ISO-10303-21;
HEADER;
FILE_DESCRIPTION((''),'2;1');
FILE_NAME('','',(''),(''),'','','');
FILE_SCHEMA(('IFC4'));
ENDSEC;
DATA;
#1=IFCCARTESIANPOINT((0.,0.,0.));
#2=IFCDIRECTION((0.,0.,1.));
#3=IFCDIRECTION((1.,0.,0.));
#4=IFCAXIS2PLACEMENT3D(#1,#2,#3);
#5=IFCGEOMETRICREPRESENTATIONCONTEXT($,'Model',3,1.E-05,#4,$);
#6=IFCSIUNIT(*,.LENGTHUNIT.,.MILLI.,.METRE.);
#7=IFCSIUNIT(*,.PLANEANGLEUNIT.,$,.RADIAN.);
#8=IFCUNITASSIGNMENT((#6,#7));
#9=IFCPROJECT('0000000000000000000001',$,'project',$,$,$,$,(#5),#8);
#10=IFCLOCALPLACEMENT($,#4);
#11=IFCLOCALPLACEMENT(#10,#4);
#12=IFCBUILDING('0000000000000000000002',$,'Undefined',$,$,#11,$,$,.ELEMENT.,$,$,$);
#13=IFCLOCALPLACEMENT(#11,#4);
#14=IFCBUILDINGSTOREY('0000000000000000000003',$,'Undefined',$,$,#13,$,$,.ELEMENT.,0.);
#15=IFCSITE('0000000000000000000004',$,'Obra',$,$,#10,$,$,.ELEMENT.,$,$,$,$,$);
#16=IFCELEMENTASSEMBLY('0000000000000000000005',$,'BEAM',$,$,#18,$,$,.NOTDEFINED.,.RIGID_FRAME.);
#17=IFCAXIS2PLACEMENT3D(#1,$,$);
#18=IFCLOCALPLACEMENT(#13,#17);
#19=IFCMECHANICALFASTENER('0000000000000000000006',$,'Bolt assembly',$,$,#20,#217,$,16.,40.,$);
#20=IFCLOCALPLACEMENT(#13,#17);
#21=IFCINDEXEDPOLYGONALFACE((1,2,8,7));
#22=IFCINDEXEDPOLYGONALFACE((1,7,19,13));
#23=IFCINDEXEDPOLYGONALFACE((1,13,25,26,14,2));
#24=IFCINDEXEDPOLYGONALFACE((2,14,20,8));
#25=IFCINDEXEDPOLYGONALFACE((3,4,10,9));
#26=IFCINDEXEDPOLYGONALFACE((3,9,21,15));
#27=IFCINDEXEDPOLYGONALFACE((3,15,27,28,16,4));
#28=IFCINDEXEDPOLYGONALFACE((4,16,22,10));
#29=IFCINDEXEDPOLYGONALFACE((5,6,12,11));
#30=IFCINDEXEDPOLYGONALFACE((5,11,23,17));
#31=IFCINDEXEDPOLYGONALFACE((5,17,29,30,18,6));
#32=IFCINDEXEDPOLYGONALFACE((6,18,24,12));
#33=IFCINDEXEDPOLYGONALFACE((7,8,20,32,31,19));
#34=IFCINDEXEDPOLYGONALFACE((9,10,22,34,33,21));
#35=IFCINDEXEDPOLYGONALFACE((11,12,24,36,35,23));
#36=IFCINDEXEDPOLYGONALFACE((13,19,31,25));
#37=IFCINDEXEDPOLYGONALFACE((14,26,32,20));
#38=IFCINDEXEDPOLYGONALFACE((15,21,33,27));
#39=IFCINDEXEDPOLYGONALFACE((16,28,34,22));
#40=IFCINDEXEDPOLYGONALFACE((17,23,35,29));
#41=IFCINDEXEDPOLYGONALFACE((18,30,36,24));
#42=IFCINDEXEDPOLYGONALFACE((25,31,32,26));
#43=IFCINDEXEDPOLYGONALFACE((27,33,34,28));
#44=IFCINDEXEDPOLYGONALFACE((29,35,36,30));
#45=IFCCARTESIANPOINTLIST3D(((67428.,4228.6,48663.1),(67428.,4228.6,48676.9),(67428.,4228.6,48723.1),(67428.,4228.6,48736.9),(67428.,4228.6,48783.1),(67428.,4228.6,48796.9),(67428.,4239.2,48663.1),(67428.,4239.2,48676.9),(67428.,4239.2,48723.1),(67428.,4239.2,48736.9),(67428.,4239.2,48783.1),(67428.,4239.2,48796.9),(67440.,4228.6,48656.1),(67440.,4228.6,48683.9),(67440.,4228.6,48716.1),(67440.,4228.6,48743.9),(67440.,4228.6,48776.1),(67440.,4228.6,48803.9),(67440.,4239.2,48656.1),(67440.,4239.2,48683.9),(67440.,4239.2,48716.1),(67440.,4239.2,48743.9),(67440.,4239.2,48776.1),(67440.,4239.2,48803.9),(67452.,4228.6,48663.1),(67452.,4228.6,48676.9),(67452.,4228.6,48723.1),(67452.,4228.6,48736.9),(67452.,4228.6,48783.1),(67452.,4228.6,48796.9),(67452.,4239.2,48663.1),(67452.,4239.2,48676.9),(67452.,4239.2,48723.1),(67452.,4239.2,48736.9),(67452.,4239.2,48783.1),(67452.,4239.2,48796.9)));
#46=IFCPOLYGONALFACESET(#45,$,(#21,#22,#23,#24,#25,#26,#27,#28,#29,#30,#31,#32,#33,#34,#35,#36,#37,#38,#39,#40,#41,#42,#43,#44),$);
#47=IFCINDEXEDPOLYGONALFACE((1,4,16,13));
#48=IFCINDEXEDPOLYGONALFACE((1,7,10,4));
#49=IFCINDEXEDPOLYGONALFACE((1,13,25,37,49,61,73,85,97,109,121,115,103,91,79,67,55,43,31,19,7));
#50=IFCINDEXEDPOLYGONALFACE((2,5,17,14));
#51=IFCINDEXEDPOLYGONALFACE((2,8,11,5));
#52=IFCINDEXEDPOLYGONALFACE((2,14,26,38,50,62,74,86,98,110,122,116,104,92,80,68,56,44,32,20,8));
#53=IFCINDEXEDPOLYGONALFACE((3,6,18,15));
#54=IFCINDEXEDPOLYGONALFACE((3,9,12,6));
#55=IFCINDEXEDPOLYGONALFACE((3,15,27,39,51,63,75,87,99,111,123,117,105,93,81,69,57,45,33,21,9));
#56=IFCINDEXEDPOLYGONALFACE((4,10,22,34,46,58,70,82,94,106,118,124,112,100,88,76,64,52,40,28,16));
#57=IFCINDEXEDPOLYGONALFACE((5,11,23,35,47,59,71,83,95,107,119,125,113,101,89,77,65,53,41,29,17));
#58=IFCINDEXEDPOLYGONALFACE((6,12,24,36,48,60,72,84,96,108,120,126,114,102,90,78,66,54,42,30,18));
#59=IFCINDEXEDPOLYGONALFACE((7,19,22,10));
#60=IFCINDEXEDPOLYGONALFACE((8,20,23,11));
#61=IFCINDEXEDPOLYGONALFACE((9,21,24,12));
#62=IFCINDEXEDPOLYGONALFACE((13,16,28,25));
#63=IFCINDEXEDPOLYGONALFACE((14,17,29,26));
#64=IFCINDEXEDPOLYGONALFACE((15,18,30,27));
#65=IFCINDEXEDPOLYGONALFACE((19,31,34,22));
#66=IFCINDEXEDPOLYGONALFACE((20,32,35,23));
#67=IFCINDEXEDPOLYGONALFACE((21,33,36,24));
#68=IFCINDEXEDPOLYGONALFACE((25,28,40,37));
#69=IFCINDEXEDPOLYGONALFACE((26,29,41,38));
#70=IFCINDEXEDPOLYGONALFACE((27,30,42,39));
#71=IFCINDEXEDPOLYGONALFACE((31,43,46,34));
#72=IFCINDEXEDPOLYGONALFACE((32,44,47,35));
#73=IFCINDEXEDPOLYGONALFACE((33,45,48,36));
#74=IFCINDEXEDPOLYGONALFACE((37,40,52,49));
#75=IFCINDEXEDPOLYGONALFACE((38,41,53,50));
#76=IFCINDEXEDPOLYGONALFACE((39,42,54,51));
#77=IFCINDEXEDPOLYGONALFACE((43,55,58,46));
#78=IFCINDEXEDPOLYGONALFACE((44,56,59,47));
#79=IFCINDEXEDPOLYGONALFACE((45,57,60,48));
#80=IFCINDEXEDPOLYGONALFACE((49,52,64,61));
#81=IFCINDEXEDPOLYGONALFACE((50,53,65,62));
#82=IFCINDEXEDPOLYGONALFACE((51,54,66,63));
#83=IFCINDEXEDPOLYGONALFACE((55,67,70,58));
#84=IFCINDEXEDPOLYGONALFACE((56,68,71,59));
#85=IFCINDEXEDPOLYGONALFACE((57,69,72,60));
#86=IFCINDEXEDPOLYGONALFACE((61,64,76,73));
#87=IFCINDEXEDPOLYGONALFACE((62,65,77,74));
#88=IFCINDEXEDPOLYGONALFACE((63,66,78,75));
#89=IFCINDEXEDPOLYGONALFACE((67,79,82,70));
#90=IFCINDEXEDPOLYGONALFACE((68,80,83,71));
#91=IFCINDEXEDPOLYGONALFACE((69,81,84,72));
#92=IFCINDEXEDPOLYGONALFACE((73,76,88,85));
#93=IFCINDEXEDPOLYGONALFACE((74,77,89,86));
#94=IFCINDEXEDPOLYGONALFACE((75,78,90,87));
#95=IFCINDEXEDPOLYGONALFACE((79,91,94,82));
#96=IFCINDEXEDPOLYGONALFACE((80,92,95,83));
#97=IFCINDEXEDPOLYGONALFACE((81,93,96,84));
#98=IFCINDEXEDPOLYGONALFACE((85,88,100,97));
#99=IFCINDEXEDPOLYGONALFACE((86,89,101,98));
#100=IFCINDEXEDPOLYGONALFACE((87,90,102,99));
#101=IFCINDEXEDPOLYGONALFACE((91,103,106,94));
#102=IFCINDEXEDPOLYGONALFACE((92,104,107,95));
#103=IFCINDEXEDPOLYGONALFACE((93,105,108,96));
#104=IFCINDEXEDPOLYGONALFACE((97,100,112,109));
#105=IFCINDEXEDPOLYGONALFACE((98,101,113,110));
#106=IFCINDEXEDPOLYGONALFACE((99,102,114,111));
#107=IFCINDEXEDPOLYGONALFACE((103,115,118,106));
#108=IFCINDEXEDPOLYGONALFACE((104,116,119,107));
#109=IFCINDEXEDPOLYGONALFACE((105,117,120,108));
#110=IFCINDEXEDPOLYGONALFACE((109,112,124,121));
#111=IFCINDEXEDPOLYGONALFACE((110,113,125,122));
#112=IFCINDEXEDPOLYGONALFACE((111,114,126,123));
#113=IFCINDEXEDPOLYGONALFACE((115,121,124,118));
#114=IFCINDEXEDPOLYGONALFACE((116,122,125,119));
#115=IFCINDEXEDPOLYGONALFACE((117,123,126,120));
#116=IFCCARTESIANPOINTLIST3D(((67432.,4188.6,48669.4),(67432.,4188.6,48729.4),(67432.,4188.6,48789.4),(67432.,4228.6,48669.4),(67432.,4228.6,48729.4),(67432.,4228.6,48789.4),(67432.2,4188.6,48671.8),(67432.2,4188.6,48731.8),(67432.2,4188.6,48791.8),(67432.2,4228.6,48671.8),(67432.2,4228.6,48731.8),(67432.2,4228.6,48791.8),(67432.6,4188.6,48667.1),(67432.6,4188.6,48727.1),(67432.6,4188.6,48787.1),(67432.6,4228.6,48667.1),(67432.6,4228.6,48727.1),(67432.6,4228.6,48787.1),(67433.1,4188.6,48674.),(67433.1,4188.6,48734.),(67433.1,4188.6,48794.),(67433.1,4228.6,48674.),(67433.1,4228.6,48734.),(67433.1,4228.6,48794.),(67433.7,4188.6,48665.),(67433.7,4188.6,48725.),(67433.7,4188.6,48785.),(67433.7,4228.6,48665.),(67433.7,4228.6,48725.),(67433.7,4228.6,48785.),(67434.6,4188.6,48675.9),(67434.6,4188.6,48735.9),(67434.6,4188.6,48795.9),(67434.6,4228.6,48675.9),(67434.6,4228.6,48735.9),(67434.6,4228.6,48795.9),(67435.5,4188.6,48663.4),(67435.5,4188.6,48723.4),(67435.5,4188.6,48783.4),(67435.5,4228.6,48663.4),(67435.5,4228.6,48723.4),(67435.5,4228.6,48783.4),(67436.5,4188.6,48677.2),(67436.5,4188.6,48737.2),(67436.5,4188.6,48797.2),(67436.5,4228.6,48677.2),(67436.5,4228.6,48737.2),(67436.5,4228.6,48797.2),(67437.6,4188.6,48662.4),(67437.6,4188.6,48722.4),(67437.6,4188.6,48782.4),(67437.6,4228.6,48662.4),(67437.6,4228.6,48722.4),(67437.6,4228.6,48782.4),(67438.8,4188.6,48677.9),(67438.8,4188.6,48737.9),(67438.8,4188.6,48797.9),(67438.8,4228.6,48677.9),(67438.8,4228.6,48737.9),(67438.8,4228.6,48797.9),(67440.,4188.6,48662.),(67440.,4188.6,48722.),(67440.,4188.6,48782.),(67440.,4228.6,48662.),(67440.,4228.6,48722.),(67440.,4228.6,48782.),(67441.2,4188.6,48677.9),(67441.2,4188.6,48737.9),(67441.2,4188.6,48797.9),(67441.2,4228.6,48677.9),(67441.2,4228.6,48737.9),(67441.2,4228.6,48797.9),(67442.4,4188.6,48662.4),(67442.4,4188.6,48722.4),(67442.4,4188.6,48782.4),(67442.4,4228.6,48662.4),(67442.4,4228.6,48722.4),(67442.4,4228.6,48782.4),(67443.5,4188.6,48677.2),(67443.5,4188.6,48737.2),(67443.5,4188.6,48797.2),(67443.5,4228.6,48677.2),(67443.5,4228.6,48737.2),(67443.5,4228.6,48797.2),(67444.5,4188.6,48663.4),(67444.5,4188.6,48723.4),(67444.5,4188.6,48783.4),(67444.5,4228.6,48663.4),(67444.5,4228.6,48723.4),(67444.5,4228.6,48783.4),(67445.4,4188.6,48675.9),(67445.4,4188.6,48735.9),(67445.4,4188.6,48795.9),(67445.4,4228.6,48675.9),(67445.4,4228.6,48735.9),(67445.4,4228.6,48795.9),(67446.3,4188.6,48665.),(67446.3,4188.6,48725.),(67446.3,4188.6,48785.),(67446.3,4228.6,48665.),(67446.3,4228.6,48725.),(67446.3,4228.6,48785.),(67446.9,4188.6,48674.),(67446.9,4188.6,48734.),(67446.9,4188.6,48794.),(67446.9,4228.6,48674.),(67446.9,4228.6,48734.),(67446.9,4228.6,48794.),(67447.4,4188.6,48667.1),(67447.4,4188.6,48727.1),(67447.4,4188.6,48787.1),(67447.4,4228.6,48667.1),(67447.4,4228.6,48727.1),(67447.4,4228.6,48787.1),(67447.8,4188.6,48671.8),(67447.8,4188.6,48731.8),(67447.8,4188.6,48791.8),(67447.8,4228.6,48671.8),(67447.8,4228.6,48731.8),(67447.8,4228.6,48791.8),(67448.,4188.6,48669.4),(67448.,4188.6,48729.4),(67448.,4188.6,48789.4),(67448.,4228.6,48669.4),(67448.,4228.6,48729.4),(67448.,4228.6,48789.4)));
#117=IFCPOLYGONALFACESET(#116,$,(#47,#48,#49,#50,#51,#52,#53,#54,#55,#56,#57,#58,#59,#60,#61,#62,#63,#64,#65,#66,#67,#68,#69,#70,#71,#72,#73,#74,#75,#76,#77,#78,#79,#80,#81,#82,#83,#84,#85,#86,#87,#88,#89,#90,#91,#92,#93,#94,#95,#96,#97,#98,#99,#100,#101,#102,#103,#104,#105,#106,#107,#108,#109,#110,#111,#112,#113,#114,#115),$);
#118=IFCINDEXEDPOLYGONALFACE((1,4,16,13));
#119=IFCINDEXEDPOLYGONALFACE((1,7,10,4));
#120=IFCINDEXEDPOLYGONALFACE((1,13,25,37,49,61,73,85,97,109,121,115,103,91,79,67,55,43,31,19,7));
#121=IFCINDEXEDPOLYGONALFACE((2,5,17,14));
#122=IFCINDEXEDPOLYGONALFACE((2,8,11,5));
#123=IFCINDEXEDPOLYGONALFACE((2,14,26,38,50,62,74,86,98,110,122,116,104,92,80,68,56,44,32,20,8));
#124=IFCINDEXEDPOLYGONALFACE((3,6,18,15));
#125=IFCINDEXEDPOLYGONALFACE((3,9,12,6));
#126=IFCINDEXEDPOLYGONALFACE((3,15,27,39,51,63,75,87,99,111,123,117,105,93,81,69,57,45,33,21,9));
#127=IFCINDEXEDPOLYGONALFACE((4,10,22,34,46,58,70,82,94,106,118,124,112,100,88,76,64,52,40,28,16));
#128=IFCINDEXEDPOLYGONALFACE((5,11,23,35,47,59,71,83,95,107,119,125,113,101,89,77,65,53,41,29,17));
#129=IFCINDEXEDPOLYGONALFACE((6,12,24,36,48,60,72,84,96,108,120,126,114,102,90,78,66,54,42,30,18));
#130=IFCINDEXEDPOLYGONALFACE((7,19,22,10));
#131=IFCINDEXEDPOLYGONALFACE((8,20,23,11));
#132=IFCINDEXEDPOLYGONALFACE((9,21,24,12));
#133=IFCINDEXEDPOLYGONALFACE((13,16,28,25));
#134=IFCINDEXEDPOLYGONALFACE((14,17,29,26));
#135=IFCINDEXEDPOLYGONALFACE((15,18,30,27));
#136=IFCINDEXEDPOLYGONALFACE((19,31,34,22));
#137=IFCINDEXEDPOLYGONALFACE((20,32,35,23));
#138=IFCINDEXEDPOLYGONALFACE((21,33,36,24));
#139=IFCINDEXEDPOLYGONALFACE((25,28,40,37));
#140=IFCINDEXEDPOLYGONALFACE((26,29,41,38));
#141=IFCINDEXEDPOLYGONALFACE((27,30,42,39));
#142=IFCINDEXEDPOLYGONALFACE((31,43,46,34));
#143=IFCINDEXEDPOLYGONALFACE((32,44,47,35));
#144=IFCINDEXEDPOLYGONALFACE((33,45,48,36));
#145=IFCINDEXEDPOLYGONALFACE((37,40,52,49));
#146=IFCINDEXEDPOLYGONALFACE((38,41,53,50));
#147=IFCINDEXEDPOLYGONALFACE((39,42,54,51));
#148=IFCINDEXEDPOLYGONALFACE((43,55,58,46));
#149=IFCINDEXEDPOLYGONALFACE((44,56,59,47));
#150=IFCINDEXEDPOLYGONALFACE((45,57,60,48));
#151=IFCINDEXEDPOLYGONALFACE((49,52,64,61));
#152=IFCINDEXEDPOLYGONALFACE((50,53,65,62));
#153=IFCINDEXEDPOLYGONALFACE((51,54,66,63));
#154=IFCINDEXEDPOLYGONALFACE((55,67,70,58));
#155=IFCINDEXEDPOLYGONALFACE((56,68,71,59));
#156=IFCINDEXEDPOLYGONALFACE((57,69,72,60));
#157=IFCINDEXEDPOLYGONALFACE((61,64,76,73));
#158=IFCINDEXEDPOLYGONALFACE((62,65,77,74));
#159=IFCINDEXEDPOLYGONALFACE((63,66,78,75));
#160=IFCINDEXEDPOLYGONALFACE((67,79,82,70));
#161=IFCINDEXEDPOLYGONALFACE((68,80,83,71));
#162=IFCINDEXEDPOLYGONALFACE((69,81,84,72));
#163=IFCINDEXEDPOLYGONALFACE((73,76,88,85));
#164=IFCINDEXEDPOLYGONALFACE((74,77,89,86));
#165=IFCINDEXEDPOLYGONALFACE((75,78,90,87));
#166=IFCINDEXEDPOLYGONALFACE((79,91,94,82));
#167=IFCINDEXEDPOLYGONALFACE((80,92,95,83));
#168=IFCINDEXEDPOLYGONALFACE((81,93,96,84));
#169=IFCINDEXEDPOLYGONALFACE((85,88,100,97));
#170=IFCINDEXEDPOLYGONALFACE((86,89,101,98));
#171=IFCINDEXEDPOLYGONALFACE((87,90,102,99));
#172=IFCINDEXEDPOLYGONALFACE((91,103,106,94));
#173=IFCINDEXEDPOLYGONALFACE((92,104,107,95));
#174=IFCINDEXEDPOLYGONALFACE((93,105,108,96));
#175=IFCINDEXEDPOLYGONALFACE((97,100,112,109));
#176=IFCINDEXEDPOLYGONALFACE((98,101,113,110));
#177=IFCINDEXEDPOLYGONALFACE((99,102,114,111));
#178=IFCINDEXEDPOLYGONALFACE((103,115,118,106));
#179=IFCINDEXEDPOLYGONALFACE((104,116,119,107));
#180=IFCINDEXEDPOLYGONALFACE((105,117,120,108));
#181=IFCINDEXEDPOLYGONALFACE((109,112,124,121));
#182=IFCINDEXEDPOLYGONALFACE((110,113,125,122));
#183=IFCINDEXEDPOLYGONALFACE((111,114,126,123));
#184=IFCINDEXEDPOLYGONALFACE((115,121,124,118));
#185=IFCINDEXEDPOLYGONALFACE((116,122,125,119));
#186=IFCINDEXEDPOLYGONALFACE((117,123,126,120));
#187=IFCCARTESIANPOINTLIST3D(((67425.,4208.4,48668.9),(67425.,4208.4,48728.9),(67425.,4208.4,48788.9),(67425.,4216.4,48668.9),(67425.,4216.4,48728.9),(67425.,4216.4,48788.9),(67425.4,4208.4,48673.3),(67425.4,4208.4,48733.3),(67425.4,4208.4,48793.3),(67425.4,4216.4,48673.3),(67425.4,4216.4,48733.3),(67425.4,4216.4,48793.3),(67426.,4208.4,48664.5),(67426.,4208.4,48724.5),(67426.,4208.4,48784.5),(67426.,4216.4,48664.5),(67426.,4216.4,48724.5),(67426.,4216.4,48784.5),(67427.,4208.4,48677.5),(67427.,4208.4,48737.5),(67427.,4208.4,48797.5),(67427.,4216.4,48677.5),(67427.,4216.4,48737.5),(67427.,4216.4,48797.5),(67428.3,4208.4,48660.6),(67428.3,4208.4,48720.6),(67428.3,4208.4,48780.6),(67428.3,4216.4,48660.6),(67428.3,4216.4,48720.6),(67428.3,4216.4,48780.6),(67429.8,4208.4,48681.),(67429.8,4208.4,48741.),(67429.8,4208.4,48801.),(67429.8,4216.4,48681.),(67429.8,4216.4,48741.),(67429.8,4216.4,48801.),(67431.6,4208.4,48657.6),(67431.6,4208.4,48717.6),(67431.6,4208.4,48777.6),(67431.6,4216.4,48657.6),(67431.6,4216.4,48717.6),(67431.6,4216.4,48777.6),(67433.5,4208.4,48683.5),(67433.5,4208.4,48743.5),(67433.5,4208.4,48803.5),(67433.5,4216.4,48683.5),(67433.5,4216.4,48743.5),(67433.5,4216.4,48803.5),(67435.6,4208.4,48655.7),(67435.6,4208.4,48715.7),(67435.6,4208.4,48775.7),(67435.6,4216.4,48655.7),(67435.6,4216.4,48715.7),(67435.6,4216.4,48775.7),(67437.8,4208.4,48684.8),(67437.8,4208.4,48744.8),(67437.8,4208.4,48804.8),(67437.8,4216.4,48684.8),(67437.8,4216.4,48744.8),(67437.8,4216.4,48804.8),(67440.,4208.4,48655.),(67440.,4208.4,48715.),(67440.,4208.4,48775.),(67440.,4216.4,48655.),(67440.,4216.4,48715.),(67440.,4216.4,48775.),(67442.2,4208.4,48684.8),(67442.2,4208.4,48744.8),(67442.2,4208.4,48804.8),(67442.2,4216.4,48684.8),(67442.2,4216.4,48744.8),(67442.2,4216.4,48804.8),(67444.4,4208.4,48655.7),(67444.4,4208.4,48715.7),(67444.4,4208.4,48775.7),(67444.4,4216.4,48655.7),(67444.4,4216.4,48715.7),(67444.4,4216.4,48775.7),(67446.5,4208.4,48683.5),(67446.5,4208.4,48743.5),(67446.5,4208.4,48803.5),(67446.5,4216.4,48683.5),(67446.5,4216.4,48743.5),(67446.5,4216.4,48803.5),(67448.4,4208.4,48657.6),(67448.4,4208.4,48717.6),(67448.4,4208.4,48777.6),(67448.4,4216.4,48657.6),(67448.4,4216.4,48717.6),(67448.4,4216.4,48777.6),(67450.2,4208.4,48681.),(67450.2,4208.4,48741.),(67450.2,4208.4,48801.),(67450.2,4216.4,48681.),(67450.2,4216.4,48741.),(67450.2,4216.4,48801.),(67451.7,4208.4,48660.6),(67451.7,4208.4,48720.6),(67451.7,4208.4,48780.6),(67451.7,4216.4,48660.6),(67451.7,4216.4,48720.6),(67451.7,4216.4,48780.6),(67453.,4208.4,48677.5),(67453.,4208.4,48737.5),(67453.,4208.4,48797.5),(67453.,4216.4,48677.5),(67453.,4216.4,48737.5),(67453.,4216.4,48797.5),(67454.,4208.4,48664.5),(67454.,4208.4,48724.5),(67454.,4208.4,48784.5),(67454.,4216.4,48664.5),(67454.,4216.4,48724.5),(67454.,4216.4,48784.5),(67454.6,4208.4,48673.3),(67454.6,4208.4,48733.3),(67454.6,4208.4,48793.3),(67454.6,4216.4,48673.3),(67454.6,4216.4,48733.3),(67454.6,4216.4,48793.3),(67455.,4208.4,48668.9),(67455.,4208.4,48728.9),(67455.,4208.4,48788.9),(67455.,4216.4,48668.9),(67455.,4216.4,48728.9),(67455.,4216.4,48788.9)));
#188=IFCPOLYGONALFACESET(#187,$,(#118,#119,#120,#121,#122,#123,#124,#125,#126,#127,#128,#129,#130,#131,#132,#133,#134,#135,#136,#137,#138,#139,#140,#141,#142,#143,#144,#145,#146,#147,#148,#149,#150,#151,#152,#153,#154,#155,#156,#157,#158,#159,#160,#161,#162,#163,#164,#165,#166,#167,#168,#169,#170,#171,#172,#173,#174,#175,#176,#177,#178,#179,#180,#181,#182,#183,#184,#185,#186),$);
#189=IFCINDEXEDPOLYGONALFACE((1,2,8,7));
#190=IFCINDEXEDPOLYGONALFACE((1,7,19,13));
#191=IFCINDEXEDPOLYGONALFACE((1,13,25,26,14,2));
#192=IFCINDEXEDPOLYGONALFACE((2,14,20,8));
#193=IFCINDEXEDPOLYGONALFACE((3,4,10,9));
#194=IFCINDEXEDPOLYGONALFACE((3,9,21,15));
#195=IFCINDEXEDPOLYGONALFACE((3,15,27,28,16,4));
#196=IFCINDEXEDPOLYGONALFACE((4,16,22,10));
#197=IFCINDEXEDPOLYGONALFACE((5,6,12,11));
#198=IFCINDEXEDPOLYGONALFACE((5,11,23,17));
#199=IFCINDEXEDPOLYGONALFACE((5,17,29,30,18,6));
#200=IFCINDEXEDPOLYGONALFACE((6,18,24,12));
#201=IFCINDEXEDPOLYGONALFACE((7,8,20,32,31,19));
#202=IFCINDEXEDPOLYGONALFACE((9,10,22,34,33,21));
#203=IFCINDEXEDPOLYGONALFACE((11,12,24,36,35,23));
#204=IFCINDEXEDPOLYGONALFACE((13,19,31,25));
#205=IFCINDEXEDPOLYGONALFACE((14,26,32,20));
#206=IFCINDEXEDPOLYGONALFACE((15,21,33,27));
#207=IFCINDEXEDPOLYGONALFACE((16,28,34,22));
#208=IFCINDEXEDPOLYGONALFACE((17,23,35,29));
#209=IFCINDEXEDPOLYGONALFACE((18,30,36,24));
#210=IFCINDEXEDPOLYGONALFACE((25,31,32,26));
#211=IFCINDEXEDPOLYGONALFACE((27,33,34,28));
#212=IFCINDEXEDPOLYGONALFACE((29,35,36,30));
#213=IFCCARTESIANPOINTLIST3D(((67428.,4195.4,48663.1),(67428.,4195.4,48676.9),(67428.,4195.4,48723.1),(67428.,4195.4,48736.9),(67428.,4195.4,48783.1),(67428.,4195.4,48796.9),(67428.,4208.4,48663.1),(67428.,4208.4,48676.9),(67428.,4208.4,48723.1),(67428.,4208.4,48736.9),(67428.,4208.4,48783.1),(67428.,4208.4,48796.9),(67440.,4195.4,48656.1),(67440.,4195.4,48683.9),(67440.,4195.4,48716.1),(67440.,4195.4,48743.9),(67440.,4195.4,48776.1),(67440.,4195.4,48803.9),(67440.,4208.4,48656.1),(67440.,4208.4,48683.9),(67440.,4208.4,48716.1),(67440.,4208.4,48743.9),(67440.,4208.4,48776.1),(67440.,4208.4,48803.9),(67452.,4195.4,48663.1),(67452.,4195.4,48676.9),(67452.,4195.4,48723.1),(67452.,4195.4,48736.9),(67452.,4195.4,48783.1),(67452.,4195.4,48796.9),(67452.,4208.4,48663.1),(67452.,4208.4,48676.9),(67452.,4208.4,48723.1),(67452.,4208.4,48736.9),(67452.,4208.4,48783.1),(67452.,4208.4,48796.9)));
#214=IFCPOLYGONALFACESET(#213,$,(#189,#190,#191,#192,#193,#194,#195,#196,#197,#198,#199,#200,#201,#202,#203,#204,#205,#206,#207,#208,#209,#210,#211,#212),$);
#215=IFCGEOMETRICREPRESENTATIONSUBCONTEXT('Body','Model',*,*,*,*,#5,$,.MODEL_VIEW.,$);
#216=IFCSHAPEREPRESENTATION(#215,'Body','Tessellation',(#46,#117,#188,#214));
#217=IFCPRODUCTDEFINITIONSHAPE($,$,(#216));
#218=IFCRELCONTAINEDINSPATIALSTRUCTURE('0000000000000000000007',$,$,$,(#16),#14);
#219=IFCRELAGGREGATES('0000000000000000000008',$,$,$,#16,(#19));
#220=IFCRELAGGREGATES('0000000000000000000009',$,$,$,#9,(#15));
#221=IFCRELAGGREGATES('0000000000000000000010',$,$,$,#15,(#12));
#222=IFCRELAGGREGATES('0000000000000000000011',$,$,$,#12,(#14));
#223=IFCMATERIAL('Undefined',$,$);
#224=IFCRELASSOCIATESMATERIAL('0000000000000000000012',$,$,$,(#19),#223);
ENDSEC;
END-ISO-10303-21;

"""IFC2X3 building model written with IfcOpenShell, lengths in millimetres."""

from ifc_helpers import new_model, si_unit, frame, origin_with_axes, origin_2d_with_axis, place, context, subcontext, project, spatial, polyline, circle, outline, extrude, source, transform, mapped, material, element, aggregate, save


model = new_model("IFC2X3")

# Units and contexts
model_context = context("Model", 3, precision=1e-05, world=origin_with_axes())
body_context = subcontext(model_context, "Body", "Model", "MODEL_VIEW")
ifc_project = project(units=[si_unit("LENGTHUNIT", "METRE", prefix="MILLI"), si_unit("PLANEANGLEUNIT", "RADIAN")], contexts=[model_context])

# Site, building, storey
site_placement = place(None, origin_with_axes())
site = spatial("IfcSite", under=ifc_project, at=site_placement, Name="Obra", CompositionType="ELEMENT")
building_placement = place(site_placement, origin_with_axes())
building = spatial("IfcBuilding", under=site, at=building_placement, Name="Undefined", CompositionType="ELEMENT")
storey_placement = place(building_placement, origin_with_axes())
storey = spatial("IfcBuildingStorey", under=building, at=storey_placement, Name="Undefined", CompositionType="ELEMENT", Elevation=0.0)

# Element assembly, mechanical fastener
ifc_material_1 = material(Name="Undefined")
shared_shape_1 = source(origin_with_axes(), body_context, "Body", "SweptSolid", [
    extrude(outline(polyline([(13.9, 0.0), (6.9, 12.0), (-6.9, 12.0), (-13.9, 0.0), (-6.9, -12.0), (6.9, -12.0), (13.9, 0.0)])), frame((0.0, -19.7, 0.0), z_axis=(0.0, 1.0, 0.0), x_axis=(1.0, 0.0, 0.0)), (0.0, 0.0, 1.0), 10.6),
    extrude(circle(Radius=8.0, at=origin_2d_with_axis()), frame((0.0, -9.1, 0.0), z_axis=(0.0, 1.0, 0.0), x_axis=(1.0, 0.0, 0.0)), (0.0, 0.0, 1.0), 40.0),
    extrude(circle(Radius=15.0, at=origin_2d_with_axis()), frame((0.0, 3.1, 0.0), z_axis=(0.0, 1.0, 0.0), x_axis=(1.0, 0.0, 0.0)), (0.0, 0.0, 1.0), 8.0),
    extrude(outline(polyline([(13.9, 0.0), (6.9, 12.0), (-6.9, 12.0), (-13.9, 0.0), (-6.9, -12.0), (6.9, -12.0), (13.9, 0.0)])), frame((0.0, 11.1, 0.0), z_axis=(0.0, 1.0, 0.0), x_axis=(1.0, 0.0, 0.0)), (0.0, 0.0, 1.0), 13.0),
])
assembly_1_placement = place(storey_placement, origin_with_axes())
assembly_1 = element("IfcElementAssembly", 1, at=assembly_1_placement, inside=storey, Name="BEAM", AssemblyPlace="NOTDEFINED", PredefinedType="RIGID_FRAME")
mechanical_fastener_1_placement = place(assembly_1_placement, frame((67490.0, 4219.5, 48850.0), z_axis=(-1.0, 0.0, 0.0), x_axis=(0.0, 0.0, -1.0)))
mechanical_fastener_1 = element("IfcMechanicalFastener", 2, at=mechanical_fastener_1_placement, material=ifc_material_1, Name="Bolt assembly", NominalDiameter=16.0, NominalLength=40.0, context=body_context, shape_type="MappedRepresentation", body=[
    mapped(shared_shape_1, transform((60.0, 0.0, 50.0))),
    mapped(shared_shape_1, transform((120.0, 0.0, 50.0))),
    mapped(shared_shape_1, transform((180.0, 0.0, 50.0))),
])
aggregate(assembly_1, [mechanical_fastener_1])

save(model, "model.ifc")
